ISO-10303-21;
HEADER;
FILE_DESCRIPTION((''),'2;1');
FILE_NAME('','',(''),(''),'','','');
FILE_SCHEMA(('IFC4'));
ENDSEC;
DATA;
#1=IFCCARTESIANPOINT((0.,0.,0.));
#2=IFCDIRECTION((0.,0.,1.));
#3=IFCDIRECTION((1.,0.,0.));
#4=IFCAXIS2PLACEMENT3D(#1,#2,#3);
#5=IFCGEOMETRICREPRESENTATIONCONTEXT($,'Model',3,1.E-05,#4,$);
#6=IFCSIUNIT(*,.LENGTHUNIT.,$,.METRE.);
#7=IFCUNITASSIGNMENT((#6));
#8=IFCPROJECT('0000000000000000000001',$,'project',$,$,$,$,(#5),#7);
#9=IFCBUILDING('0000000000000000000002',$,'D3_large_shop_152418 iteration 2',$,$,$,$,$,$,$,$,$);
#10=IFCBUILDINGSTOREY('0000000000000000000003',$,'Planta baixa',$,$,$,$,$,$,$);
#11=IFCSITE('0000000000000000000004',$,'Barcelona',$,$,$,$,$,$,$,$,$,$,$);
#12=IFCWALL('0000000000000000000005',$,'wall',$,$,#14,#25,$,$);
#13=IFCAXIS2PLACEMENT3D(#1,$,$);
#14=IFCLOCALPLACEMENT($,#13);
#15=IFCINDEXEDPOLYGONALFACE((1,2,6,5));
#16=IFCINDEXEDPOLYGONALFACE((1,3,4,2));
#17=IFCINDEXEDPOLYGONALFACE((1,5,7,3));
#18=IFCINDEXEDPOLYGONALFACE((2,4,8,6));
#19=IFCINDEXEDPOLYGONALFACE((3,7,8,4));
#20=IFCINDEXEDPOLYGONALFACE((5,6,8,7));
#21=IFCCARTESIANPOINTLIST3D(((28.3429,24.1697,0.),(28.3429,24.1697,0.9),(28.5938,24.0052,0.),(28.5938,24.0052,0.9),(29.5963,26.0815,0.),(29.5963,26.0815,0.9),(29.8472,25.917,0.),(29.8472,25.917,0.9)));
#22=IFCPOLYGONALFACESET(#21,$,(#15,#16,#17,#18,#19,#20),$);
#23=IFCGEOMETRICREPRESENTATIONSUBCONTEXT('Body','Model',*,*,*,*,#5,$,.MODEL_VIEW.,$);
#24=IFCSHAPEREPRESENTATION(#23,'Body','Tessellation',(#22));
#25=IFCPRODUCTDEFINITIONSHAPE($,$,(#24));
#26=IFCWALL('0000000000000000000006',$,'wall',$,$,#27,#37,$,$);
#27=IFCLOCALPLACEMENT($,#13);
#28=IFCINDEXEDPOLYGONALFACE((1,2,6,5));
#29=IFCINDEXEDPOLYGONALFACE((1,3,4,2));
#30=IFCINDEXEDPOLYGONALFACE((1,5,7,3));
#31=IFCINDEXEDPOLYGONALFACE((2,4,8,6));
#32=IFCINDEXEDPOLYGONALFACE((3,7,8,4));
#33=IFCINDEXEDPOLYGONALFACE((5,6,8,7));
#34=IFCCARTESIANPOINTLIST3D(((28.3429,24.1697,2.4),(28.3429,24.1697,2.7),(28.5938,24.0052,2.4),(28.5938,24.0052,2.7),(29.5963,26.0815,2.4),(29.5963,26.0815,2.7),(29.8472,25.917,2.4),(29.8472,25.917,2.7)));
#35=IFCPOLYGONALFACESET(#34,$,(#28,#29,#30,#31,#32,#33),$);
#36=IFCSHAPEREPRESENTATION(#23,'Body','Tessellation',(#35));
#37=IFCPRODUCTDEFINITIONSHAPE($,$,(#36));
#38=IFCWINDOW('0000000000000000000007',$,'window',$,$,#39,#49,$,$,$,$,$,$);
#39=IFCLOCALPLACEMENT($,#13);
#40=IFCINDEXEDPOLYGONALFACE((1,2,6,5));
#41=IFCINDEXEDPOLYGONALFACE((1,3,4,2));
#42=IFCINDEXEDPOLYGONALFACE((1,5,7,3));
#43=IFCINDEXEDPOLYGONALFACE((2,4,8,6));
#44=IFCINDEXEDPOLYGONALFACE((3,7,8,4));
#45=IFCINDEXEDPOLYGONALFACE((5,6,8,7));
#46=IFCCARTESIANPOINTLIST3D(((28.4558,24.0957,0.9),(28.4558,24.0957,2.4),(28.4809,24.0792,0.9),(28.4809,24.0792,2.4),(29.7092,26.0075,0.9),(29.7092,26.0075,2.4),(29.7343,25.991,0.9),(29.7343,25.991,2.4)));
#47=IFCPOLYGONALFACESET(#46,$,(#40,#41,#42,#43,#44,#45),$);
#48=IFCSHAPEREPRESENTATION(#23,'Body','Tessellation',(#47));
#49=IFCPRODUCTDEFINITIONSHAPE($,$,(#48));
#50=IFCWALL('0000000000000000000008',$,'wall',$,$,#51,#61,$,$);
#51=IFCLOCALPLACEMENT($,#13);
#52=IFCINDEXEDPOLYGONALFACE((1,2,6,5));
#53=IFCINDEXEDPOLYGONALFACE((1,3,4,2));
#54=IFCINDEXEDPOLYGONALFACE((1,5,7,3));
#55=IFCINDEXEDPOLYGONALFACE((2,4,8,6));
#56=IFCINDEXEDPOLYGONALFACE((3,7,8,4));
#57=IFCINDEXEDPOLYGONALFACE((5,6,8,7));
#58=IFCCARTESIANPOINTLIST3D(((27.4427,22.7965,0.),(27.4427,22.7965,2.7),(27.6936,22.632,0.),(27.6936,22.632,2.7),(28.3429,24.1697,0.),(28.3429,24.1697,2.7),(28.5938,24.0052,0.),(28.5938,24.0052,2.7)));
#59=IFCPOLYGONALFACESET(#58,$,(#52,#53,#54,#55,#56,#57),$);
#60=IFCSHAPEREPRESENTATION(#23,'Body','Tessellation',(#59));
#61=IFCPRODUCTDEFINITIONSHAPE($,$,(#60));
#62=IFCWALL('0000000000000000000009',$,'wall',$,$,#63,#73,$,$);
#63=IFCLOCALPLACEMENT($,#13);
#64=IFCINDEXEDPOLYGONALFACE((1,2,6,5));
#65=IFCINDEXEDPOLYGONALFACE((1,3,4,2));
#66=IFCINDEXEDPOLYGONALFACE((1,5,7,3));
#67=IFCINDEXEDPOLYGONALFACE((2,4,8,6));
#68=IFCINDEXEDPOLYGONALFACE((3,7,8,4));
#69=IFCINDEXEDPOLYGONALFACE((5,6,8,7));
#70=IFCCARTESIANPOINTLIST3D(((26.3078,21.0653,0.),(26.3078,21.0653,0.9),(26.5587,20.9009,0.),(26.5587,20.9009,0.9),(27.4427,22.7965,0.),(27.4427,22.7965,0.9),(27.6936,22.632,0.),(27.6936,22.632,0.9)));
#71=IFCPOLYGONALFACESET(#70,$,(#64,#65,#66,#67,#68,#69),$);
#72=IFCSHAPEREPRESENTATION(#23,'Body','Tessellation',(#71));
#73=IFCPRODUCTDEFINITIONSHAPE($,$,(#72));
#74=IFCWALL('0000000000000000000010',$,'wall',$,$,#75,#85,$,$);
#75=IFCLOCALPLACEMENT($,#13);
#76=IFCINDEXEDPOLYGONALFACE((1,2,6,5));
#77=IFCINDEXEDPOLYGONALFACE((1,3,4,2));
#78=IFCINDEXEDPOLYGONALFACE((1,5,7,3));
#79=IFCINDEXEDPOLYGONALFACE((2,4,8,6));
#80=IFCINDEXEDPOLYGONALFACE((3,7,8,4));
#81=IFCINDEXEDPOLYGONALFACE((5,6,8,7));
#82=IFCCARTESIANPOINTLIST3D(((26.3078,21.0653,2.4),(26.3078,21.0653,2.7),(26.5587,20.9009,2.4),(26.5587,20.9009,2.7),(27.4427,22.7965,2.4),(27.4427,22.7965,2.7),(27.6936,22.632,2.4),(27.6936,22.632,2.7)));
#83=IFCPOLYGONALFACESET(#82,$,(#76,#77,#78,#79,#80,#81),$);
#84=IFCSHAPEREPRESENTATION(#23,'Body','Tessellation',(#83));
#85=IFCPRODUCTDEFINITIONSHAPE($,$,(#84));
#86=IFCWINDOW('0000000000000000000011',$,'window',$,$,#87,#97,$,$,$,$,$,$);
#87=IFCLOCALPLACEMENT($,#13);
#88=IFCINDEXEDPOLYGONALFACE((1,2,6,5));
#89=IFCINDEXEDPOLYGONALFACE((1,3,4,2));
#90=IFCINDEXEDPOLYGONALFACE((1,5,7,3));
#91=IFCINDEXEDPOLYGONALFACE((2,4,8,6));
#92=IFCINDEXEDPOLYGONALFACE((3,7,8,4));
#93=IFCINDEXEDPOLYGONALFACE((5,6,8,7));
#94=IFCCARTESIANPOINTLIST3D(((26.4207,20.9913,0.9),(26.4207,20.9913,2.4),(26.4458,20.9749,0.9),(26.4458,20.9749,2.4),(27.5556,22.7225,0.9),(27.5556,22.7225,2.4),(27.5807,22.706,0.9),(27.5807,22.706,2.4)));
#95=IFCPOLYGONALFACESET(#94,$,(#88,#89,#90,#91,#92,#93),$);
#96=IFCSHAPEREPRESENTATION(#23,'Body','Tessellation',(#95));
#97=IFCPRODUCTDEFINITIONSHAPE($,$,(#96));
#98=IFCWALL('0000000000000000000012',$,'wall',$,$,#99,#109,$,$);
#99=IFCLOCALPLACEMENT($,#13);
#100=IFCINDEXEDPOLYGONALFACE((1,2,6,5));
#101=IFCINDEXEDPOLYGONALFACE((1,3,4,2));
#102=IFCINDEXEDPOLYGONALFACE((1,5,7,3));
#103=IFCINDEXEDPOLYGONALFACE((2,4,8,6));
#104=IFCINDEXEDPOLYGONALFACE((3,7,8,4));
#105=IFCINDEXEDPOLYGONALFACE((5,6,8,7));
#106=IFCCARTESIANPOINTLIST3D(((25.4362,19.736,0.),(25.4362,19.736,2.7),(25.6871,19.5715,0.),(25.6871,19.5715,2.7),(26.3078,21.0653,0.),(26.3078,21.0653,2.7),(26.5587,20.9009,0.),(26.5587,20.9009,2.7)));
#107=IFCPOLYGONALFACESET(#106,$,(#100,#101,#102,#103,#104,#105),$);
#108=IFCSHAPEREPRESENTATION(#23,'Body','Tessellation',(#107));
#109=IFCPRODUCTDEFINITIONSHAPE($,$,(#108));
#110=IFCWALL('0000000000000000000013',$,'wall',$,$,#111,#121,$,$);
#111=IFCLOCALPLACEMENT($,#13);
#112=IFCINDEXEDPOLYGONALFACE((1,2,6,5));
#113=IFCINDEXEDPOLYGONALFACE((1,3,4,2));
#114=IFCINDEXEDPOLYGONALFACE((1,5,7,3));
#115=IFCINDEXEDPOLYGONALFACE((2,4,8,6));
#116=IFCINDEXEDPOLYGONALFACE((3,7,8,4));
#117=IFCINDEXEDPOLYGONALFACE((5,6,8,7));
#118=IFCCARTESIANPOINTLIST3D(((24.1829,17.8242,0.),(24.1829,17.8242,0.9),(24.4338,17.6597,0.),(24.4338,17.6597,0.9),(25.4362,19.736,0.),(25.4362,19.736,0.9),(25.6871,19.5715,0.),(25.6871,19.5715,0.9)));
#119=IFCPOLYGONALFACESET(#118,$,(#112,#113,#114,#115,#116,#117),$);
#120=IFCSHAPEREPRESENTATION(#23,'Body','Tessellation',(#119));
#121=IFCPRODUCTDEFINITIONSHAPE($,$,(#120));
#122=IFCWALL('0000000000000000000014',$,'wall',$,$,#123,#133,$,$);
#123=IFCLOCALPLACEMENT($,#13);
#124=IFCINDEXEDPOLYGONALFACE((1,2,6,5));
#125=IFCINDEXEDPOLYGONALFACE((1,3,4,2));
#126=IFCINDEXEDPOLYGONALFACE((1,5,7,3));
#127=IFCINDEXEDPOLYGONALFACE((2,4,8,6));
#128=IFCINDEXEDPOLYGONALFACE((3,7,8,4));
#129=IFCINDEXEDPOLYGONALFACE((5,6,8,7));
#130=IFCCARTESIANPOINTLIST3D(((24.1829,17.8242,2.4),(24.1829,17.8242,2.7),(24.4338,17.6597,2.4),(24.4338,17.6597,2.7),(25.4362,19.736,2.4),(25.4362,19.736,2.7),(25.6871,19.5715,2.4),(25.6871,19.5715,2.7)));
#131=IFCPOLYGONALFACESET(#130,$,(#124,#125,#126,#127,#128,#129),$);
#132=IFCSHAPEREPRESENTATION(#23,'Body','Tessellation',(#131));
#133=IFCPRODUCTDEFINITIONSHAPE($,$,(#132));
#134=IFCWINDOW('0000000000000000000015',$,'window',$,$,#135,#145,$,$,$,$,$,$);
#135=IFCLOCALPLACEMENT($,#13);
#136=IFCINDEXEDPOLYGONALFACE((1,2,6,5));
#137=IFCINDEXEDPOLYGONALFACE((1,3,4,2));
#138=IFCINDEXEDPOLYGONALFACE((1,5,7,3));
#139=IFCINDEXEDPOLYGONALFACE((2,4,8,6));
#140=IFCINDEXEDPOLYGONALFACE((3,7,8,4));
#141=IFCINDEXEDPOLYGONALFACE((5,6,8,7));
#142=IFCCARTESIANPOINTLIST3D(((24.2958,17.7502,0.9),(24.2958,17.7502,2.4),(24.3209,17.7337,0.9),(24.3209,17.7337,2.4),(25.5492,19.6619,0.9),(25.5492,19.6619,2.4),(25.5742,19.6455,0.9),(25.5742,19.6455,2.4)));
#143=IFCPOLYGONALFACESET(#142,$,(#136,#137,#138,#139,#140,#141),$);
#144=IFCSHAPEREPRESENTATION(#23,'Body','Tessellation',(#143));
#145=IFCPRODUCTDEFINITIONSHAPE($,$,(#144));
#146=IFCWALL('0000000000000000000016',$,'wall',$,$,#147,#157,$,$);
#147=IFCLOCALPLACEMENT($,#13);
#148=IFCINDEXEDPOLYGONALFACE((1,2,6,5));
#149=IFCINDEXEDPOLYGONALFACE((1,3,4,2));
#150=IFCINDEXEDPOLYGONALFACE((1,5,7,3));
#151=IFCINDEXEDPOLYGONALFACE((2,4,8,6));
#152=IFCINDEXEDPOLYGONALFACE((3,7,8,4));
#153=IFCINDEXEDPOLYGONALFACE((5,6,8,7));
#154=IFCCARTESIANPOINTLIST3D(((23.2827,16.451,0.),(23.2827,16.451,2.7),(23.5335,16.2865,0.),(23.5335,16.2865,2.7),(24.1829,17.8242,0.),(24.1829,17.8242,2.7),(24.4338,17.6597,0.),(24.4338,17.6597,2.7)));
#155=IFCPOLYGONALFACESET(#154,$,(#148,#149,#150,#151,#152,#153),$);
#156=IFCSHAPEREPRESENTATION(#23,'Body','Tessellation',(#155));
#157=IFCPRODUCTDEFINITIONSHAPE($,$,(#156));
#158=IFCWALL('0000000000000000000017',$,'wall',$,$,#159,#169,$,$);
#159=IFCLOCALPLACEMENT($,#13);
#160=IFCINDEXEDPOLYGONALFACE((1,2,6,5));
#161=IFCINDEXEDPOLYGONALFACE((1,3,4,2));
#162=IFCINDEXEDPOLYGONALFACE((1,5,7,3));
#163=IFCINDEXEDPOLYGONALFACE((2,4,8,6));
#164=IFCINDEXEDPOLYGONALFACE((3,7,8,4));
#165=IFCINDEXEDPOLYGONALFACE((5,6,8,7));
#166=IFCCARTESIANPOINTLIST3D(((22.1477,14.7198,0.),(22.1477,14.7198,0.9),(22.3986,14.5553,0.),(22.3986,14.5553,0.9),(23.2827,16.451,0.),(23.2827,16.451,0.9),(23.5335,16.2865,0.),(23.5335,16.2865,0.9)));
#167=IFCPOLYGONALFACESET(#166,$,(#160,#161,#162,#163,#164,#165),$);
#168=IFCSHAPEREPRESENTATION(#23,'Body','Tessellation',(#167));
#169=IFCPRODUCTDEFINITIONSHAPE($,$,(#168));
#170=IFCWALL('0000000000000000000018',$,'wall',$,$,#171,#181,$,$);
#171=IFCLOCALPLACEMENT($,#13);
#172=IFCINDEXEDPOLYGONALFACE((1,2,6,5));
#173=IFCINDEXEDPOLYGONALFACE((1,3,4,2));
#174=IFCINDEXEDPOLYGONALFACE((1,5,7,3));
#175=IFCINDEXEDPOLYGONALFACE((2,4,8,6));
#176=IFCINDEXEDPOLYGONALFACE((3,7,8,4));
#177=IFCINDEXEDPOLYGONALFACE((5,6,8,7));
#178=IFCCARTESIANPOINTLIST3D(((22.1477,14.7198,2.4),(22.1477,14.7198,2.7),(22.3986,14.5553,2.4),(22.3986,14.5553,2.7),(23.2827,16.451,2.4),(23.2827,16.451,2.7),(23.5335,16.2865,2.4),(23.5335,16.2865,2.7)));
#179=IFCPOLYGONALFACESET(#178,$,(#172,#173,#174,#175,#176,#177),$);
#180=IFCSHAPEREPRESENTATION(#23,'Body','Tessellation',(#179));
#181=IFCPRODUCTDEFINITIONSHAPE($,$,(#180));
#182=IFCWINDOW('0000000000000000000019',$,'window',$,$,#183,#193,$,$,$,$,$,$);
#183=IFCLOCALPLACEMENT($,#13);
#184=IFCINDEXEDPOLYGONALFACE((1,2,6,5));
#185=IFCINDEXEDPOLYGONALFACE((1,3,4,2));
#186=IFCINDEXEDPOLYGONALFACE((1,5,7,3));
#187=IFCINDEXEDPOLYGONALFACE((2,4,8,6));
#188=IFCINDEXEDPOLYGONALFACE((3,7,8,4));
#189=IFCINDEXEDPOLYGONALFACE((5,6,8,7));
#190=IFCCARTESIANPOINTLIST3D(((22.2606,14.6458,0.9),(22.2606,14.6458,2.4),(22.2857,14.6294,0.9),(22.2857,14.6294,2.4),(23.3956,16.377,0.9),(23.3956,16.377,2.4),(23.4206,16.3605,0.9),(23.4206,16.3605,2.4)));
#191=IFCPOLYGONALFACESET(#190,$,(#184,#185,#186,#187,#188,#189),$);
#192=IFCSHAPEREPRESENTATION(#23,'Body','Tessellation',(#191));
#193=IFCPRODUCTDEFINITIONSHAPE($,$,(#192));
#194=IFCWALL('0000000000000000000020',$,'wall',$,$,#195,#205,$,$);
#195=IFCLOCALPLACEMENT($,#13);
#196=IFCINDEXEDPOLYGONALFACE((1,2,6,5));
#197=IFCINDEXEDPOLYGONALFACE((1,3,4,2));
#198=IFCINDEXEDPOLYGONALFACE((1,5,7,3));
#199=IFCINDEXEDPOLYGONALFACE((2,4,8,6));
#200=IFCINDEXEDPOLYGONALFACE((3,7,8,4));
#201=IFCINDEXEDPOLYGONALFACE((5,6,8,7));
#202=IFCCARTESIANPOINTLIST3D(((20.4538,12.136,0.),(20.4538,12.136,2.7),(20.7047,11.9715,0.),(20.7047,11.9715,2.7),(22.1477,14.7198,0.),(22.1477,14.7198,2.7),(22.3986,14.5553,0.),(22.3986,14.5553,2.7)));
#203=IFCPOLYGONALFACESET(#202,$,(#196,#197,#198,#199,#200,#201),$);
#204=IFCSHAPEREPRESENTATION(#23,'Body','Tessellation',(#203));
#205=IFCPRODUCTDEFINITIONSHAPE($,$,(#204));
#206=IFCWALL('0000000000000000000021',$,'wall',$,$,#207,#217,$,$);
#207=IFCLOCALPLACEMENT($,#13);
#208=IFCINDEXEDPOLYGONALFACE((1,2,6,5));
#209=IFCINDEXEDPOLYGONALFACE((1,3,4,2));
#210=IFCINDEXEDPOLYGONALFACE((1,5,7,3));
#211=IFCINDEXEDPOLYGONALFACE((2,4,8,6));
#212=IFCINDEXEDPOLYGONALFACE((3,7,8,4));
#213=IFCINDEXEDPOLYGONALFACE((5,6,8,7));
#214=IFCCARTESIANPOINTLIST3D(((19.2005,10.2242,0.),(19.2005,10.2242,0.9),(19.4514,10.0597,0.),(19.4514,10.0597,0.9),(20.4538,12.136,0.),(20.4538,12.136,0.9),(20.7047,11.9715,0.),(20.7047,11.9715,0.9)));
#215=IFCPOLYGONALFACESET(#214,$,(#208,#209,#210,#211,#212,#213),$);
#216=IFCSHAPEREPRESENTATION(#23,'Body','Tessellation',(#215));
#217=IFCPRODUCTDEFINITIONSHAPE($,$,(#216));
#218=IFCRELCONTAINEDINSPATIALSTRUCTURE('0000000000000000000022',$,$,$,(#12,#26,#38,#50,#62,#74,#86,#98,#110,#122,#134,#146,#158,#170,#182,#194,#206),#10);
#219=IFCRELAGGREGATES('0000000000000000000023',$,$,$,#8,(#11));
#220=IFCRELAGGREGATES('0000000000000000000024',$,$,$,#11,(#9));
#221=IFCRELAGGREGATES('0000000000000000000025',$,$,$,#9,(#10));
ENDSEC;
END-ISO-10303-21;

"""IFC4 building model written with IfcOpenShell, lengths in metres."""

from ifc_helpers import new_model, si_unit, frame, origin, origin_with_axes, place, context, subcontext, project, spatial, polyline, outline, extrude, element, save


model = new_model("IFC4")

# Units and contexts
model_context = context("Model", 3, precision=1e-05, world=origin_with_axes())
body_context = subcontext(model_context, "Body", "Model", "MODEL_VIEW")
ifc_project = project(units=[si_unit("LENGTHUNIT", "METRE")], contexts=[model_context])

# Site, building, storey
site = spatial("IfcSite", under=ifc_project, Name="Barcelona")
building = spatial("IfcBuilding", under=site, Name="D3_large_shop_152418 iteration 2")
storey = spatial("IfcBuildingStorey", under=building, Name="Planta baixa")

# Walls
wall_1_placement = place(None, origin_with_axes())
element("IfcWall", 1, at=wall_1_placement, inside=storey, Name="wall", context=body_context, shape_type="SweptSolid", body=[
    extrude(outline(polyline([(29.8472, 25.917), (28.5938, 24.0052), (28.3429, 24.1697), (29.5963, 26.0815), (29.8472, 25.917)])), origin(), (0.0, 0.0, 1.0), 0.9),
])
wall_2_placement = place(None, origin_with_axes())
element("IfcWall", 2, at=wall_2_placement, inside=storey, Name="wall", context=body_context, shape_type="SweptSolid", body=[
    extrude(outline(polyline([(29.8472, 25.917), (28.5938, 24.0052), (28.3429, 24.1697), (29.5963, 26.0815), (29.8472, 25.917)])), frame((0.0, 0.0, 2.4)), (0.0, 0.0, 1.0), 0.3),
])

# Window
window_1_placement = place(None, origin_with_axes())
element("IfcWindow", 3, at=window_1_placement, inside=storey, Name="window", context=body_context, shape_type="SweptSolid", body=[
    extrude(outline(polyline([(29.7343, 25.991), (28.4809, 24.0792), (28.4558, 24.0957), (29.7092, 26.0075), (29.7343, 25.991)])), frame((0.0, 0.0, 0.9)), (0.0, 0.0, 1.0), 1.5),
])

# Walls
wall_3_placement = place(None, origin_with_axes())
element("IfcWall", 4, at=wall_3_placement, inside=storey, Name="wall", context=body_context, shape_type="SweptSolid", body=[
    extrude(outline(polyline([(28.5938, 24.0052), (27.6936, 22.632), (27.4427, 22.7965), (28.3429, 24.1697), (28.5938, 24.0052)])), origin(), (0.0, 0.0, 1.0), 2.7),
])
wall_4_placement = place(None, origin_with_axes())
element("IfcWall", 5, at=wall_4_placement, inside=storey, Name="wall", context=body_context, shape_type="SweptSolid", body=[
    extrude(outline(polyline([(27.6936, 22.632), (26.5587, 20.9009), (26.3078, 21.0653), (27.4427, 22.7965), (27.6936, 22.632)])), origin(), (0.0, 0.0, 1.0), 0.9),
])
wall_5_placement = place(None, origin_with_axes())
element("IfcWall", 6, at=wall_5_placement, inside=storey, Name="wall", context=body_context, shape_type="SweptSolid", body=[
    extrude(outline(polyline([(27.6936, 22.632), (26.5587, 20.9009), (26.3078, 21.0653), (27.4427, 22.7965), (27.6936, 22.632)])), frame((0.0, 0.0, 2.4)), (0.0, 0.0, 1.0), 0.3),
])

# Window
window_2_placement = place(None, origin_with_axes())
element("IfcWindow", 7, at=window_2_placement, inside=storey, Name="window", context=body_context, shape_type="SweptSolid", body=[
    extrude(outline(polyline([(27.5807, 22.706), (26.4458, 20.9749), (26.4207, 20.9913), (27.5556, 22.7225), (27.5807, 22.706)])), frame((0.0, 0.0, 0.9)), (0.0, 0.0, 1.0), 1.5),
])

# Walls
wall_6_placement = place(None, origin_with_axes())
element("IfcWall", 8, at=wall_6_placement, inside=storey, Name="wall", context=body_context, shape_type="SweptSolid", body=[
    extrude(outline(polyline([(26.5587, 20.9009), (25.6871, 19.5715), (25.4362, 19.736), (26.3078, 21.0653), (26.5587, 20.9009)])), origin(), (0.0, 0.0, 1.0), 2.7),
])
wall_7_placement = place(None, origin_with_axes())
element("IfcWall", 9, at=wall_7_placement, inside=storey, Name="wall", context=body_context, shape_type="SweptSolid", body=[
    extrude(outline(polyline([(25.6871, 19.5715), (24.4338, 17.6597), (24.1829, 17.8242), (25.4362, 19.736), (25.6871, 19.5715)])), origin(), (0.0, 0.0, 1.0), 0.9),
])
wall_8_placement = place(None, origin_with_axes())
element("IfcWall", 10, at=wall_8_placement, inside=storey, Name="wall", context=body_context, shape_type="SweptSolid", body=[
    extrude(outline(polyline([(25.6871, 19.5715), (24.4338, 17.6597), (24.1829, 17.8242), (25.4362, 19.736), (25.6871, 19.5715)])), frame((0.0, 0.0, 2.4)), (0.0, 0.0, 1.0), 0.3),
])

# Window
window_3_placement = place(None, origin_with_axes())
element("IfcWindow", 11, at=window_3_placement, inside=storey, Name="window", context=body_context, shape_type="SweptSolid", body=[
    extrude(outline(polyline([(25.5742, 19.6455), (24.3209, 17.7337), (24.2958, 17.7502), (25.5492, 19.6619), (25.5742, 19.6455)])), frame((0.0, 0.0, 0.9)), (0.0, 0.0, 1.0), 1.5),
])

# Walls
wall_9_placement = place(None, origin_with_axes())
element("IfcWall", 12, at=wall_9_placement, inside=storey, Name="wall", context=body_context, shape_type="SweptSolid", body=[
    extrude(outline(polyline([(24.4338, 17.6597), (23.5335, 16.2865), (23.2827, 16.451), (24.1829, 17.8242), (24.4338, 17.6597)])), origin(), (0.0, 0.0, 1.0), 2.7),
])
wall_10_placement = place(None, origin_with_axes())
element("IfcWall", 13, at=wall_10_placement, inside=storey, Name="wall", context=body_context, shape_type="SweptSolid", body=[
    extrude(outline(polyline([(23.5335, 16.2865), (22.3986, 14.5553), (22.1477, 14.7198), (23.2827, 16.451), (23.5335, 16.2865)])), origin(), (0.0, 0.0, 1.0), 0.9),
])
wall_11_placement = place(None, origin_with_axes())
element("IfcWall", 14, at=wall_11_placement, inside=storey, Name="wall", context=body_context, shape_type="SweptSolid", body=[
    extrude(outline(polyline([(23.5335, 16.2865), (22.3986, 14.5553), (22.1477, 14.7198), (23.2827, 16.451), (23.5335, 16.2865)])), frame((0.0, 0.0, 2.4)), (0.0, 0.0, 1.0), 0.3),
])

# Window
window_4_placement = place(None, origin_with_axes())
element("IfcWindow", 15, at=window_4_placement, inside=storey, Name="window", context=body_context, shape_type="SweptSolid", body=[
    extrude(outline(polyline([(23.4206, 16.3605), (22.2857, 14.6294), (22.2606, 14.6458), (23.3956, 16.377), (23.4206, 16.3605)])), frame((0.0, 0.0, 0.9)), (0.0, 0.0, 1.0), 1.5),
])

# Walls
wall_12_placement = place(None, origin_with_axes())
element("IfcWall", 16, at=wall_12_placement, inside=storey, Name="wall", context=body_context, shape_type="SweptSolid", body=[
    extrude(outline(polyline([(22.3986, 14.5553), (20.7047, 11.9715), (20.4538, 12.136), (22.1477, 14.7198), (22.3986, 14.5553)])), origin(), (0.0, 0.0, 1.0), 2.7),
])
wall_13_placement = place(None, origin_with_axes())
element("IfcWall", 17, at=wall_13_placement, inside=storey, Name="wall", context=body_context, shape_type="SweptSolid", body=[
    extrude(outline(polyline([(20.7047, 11.9715), (19.4514, 10.0597), (19.2005, 10.2242), (20.4538, 12.136), (20.7047, 11.9715)])), origin(), (0.0, 0.0, 1.0), 0.9),
])

save(model, "model.ifc")
